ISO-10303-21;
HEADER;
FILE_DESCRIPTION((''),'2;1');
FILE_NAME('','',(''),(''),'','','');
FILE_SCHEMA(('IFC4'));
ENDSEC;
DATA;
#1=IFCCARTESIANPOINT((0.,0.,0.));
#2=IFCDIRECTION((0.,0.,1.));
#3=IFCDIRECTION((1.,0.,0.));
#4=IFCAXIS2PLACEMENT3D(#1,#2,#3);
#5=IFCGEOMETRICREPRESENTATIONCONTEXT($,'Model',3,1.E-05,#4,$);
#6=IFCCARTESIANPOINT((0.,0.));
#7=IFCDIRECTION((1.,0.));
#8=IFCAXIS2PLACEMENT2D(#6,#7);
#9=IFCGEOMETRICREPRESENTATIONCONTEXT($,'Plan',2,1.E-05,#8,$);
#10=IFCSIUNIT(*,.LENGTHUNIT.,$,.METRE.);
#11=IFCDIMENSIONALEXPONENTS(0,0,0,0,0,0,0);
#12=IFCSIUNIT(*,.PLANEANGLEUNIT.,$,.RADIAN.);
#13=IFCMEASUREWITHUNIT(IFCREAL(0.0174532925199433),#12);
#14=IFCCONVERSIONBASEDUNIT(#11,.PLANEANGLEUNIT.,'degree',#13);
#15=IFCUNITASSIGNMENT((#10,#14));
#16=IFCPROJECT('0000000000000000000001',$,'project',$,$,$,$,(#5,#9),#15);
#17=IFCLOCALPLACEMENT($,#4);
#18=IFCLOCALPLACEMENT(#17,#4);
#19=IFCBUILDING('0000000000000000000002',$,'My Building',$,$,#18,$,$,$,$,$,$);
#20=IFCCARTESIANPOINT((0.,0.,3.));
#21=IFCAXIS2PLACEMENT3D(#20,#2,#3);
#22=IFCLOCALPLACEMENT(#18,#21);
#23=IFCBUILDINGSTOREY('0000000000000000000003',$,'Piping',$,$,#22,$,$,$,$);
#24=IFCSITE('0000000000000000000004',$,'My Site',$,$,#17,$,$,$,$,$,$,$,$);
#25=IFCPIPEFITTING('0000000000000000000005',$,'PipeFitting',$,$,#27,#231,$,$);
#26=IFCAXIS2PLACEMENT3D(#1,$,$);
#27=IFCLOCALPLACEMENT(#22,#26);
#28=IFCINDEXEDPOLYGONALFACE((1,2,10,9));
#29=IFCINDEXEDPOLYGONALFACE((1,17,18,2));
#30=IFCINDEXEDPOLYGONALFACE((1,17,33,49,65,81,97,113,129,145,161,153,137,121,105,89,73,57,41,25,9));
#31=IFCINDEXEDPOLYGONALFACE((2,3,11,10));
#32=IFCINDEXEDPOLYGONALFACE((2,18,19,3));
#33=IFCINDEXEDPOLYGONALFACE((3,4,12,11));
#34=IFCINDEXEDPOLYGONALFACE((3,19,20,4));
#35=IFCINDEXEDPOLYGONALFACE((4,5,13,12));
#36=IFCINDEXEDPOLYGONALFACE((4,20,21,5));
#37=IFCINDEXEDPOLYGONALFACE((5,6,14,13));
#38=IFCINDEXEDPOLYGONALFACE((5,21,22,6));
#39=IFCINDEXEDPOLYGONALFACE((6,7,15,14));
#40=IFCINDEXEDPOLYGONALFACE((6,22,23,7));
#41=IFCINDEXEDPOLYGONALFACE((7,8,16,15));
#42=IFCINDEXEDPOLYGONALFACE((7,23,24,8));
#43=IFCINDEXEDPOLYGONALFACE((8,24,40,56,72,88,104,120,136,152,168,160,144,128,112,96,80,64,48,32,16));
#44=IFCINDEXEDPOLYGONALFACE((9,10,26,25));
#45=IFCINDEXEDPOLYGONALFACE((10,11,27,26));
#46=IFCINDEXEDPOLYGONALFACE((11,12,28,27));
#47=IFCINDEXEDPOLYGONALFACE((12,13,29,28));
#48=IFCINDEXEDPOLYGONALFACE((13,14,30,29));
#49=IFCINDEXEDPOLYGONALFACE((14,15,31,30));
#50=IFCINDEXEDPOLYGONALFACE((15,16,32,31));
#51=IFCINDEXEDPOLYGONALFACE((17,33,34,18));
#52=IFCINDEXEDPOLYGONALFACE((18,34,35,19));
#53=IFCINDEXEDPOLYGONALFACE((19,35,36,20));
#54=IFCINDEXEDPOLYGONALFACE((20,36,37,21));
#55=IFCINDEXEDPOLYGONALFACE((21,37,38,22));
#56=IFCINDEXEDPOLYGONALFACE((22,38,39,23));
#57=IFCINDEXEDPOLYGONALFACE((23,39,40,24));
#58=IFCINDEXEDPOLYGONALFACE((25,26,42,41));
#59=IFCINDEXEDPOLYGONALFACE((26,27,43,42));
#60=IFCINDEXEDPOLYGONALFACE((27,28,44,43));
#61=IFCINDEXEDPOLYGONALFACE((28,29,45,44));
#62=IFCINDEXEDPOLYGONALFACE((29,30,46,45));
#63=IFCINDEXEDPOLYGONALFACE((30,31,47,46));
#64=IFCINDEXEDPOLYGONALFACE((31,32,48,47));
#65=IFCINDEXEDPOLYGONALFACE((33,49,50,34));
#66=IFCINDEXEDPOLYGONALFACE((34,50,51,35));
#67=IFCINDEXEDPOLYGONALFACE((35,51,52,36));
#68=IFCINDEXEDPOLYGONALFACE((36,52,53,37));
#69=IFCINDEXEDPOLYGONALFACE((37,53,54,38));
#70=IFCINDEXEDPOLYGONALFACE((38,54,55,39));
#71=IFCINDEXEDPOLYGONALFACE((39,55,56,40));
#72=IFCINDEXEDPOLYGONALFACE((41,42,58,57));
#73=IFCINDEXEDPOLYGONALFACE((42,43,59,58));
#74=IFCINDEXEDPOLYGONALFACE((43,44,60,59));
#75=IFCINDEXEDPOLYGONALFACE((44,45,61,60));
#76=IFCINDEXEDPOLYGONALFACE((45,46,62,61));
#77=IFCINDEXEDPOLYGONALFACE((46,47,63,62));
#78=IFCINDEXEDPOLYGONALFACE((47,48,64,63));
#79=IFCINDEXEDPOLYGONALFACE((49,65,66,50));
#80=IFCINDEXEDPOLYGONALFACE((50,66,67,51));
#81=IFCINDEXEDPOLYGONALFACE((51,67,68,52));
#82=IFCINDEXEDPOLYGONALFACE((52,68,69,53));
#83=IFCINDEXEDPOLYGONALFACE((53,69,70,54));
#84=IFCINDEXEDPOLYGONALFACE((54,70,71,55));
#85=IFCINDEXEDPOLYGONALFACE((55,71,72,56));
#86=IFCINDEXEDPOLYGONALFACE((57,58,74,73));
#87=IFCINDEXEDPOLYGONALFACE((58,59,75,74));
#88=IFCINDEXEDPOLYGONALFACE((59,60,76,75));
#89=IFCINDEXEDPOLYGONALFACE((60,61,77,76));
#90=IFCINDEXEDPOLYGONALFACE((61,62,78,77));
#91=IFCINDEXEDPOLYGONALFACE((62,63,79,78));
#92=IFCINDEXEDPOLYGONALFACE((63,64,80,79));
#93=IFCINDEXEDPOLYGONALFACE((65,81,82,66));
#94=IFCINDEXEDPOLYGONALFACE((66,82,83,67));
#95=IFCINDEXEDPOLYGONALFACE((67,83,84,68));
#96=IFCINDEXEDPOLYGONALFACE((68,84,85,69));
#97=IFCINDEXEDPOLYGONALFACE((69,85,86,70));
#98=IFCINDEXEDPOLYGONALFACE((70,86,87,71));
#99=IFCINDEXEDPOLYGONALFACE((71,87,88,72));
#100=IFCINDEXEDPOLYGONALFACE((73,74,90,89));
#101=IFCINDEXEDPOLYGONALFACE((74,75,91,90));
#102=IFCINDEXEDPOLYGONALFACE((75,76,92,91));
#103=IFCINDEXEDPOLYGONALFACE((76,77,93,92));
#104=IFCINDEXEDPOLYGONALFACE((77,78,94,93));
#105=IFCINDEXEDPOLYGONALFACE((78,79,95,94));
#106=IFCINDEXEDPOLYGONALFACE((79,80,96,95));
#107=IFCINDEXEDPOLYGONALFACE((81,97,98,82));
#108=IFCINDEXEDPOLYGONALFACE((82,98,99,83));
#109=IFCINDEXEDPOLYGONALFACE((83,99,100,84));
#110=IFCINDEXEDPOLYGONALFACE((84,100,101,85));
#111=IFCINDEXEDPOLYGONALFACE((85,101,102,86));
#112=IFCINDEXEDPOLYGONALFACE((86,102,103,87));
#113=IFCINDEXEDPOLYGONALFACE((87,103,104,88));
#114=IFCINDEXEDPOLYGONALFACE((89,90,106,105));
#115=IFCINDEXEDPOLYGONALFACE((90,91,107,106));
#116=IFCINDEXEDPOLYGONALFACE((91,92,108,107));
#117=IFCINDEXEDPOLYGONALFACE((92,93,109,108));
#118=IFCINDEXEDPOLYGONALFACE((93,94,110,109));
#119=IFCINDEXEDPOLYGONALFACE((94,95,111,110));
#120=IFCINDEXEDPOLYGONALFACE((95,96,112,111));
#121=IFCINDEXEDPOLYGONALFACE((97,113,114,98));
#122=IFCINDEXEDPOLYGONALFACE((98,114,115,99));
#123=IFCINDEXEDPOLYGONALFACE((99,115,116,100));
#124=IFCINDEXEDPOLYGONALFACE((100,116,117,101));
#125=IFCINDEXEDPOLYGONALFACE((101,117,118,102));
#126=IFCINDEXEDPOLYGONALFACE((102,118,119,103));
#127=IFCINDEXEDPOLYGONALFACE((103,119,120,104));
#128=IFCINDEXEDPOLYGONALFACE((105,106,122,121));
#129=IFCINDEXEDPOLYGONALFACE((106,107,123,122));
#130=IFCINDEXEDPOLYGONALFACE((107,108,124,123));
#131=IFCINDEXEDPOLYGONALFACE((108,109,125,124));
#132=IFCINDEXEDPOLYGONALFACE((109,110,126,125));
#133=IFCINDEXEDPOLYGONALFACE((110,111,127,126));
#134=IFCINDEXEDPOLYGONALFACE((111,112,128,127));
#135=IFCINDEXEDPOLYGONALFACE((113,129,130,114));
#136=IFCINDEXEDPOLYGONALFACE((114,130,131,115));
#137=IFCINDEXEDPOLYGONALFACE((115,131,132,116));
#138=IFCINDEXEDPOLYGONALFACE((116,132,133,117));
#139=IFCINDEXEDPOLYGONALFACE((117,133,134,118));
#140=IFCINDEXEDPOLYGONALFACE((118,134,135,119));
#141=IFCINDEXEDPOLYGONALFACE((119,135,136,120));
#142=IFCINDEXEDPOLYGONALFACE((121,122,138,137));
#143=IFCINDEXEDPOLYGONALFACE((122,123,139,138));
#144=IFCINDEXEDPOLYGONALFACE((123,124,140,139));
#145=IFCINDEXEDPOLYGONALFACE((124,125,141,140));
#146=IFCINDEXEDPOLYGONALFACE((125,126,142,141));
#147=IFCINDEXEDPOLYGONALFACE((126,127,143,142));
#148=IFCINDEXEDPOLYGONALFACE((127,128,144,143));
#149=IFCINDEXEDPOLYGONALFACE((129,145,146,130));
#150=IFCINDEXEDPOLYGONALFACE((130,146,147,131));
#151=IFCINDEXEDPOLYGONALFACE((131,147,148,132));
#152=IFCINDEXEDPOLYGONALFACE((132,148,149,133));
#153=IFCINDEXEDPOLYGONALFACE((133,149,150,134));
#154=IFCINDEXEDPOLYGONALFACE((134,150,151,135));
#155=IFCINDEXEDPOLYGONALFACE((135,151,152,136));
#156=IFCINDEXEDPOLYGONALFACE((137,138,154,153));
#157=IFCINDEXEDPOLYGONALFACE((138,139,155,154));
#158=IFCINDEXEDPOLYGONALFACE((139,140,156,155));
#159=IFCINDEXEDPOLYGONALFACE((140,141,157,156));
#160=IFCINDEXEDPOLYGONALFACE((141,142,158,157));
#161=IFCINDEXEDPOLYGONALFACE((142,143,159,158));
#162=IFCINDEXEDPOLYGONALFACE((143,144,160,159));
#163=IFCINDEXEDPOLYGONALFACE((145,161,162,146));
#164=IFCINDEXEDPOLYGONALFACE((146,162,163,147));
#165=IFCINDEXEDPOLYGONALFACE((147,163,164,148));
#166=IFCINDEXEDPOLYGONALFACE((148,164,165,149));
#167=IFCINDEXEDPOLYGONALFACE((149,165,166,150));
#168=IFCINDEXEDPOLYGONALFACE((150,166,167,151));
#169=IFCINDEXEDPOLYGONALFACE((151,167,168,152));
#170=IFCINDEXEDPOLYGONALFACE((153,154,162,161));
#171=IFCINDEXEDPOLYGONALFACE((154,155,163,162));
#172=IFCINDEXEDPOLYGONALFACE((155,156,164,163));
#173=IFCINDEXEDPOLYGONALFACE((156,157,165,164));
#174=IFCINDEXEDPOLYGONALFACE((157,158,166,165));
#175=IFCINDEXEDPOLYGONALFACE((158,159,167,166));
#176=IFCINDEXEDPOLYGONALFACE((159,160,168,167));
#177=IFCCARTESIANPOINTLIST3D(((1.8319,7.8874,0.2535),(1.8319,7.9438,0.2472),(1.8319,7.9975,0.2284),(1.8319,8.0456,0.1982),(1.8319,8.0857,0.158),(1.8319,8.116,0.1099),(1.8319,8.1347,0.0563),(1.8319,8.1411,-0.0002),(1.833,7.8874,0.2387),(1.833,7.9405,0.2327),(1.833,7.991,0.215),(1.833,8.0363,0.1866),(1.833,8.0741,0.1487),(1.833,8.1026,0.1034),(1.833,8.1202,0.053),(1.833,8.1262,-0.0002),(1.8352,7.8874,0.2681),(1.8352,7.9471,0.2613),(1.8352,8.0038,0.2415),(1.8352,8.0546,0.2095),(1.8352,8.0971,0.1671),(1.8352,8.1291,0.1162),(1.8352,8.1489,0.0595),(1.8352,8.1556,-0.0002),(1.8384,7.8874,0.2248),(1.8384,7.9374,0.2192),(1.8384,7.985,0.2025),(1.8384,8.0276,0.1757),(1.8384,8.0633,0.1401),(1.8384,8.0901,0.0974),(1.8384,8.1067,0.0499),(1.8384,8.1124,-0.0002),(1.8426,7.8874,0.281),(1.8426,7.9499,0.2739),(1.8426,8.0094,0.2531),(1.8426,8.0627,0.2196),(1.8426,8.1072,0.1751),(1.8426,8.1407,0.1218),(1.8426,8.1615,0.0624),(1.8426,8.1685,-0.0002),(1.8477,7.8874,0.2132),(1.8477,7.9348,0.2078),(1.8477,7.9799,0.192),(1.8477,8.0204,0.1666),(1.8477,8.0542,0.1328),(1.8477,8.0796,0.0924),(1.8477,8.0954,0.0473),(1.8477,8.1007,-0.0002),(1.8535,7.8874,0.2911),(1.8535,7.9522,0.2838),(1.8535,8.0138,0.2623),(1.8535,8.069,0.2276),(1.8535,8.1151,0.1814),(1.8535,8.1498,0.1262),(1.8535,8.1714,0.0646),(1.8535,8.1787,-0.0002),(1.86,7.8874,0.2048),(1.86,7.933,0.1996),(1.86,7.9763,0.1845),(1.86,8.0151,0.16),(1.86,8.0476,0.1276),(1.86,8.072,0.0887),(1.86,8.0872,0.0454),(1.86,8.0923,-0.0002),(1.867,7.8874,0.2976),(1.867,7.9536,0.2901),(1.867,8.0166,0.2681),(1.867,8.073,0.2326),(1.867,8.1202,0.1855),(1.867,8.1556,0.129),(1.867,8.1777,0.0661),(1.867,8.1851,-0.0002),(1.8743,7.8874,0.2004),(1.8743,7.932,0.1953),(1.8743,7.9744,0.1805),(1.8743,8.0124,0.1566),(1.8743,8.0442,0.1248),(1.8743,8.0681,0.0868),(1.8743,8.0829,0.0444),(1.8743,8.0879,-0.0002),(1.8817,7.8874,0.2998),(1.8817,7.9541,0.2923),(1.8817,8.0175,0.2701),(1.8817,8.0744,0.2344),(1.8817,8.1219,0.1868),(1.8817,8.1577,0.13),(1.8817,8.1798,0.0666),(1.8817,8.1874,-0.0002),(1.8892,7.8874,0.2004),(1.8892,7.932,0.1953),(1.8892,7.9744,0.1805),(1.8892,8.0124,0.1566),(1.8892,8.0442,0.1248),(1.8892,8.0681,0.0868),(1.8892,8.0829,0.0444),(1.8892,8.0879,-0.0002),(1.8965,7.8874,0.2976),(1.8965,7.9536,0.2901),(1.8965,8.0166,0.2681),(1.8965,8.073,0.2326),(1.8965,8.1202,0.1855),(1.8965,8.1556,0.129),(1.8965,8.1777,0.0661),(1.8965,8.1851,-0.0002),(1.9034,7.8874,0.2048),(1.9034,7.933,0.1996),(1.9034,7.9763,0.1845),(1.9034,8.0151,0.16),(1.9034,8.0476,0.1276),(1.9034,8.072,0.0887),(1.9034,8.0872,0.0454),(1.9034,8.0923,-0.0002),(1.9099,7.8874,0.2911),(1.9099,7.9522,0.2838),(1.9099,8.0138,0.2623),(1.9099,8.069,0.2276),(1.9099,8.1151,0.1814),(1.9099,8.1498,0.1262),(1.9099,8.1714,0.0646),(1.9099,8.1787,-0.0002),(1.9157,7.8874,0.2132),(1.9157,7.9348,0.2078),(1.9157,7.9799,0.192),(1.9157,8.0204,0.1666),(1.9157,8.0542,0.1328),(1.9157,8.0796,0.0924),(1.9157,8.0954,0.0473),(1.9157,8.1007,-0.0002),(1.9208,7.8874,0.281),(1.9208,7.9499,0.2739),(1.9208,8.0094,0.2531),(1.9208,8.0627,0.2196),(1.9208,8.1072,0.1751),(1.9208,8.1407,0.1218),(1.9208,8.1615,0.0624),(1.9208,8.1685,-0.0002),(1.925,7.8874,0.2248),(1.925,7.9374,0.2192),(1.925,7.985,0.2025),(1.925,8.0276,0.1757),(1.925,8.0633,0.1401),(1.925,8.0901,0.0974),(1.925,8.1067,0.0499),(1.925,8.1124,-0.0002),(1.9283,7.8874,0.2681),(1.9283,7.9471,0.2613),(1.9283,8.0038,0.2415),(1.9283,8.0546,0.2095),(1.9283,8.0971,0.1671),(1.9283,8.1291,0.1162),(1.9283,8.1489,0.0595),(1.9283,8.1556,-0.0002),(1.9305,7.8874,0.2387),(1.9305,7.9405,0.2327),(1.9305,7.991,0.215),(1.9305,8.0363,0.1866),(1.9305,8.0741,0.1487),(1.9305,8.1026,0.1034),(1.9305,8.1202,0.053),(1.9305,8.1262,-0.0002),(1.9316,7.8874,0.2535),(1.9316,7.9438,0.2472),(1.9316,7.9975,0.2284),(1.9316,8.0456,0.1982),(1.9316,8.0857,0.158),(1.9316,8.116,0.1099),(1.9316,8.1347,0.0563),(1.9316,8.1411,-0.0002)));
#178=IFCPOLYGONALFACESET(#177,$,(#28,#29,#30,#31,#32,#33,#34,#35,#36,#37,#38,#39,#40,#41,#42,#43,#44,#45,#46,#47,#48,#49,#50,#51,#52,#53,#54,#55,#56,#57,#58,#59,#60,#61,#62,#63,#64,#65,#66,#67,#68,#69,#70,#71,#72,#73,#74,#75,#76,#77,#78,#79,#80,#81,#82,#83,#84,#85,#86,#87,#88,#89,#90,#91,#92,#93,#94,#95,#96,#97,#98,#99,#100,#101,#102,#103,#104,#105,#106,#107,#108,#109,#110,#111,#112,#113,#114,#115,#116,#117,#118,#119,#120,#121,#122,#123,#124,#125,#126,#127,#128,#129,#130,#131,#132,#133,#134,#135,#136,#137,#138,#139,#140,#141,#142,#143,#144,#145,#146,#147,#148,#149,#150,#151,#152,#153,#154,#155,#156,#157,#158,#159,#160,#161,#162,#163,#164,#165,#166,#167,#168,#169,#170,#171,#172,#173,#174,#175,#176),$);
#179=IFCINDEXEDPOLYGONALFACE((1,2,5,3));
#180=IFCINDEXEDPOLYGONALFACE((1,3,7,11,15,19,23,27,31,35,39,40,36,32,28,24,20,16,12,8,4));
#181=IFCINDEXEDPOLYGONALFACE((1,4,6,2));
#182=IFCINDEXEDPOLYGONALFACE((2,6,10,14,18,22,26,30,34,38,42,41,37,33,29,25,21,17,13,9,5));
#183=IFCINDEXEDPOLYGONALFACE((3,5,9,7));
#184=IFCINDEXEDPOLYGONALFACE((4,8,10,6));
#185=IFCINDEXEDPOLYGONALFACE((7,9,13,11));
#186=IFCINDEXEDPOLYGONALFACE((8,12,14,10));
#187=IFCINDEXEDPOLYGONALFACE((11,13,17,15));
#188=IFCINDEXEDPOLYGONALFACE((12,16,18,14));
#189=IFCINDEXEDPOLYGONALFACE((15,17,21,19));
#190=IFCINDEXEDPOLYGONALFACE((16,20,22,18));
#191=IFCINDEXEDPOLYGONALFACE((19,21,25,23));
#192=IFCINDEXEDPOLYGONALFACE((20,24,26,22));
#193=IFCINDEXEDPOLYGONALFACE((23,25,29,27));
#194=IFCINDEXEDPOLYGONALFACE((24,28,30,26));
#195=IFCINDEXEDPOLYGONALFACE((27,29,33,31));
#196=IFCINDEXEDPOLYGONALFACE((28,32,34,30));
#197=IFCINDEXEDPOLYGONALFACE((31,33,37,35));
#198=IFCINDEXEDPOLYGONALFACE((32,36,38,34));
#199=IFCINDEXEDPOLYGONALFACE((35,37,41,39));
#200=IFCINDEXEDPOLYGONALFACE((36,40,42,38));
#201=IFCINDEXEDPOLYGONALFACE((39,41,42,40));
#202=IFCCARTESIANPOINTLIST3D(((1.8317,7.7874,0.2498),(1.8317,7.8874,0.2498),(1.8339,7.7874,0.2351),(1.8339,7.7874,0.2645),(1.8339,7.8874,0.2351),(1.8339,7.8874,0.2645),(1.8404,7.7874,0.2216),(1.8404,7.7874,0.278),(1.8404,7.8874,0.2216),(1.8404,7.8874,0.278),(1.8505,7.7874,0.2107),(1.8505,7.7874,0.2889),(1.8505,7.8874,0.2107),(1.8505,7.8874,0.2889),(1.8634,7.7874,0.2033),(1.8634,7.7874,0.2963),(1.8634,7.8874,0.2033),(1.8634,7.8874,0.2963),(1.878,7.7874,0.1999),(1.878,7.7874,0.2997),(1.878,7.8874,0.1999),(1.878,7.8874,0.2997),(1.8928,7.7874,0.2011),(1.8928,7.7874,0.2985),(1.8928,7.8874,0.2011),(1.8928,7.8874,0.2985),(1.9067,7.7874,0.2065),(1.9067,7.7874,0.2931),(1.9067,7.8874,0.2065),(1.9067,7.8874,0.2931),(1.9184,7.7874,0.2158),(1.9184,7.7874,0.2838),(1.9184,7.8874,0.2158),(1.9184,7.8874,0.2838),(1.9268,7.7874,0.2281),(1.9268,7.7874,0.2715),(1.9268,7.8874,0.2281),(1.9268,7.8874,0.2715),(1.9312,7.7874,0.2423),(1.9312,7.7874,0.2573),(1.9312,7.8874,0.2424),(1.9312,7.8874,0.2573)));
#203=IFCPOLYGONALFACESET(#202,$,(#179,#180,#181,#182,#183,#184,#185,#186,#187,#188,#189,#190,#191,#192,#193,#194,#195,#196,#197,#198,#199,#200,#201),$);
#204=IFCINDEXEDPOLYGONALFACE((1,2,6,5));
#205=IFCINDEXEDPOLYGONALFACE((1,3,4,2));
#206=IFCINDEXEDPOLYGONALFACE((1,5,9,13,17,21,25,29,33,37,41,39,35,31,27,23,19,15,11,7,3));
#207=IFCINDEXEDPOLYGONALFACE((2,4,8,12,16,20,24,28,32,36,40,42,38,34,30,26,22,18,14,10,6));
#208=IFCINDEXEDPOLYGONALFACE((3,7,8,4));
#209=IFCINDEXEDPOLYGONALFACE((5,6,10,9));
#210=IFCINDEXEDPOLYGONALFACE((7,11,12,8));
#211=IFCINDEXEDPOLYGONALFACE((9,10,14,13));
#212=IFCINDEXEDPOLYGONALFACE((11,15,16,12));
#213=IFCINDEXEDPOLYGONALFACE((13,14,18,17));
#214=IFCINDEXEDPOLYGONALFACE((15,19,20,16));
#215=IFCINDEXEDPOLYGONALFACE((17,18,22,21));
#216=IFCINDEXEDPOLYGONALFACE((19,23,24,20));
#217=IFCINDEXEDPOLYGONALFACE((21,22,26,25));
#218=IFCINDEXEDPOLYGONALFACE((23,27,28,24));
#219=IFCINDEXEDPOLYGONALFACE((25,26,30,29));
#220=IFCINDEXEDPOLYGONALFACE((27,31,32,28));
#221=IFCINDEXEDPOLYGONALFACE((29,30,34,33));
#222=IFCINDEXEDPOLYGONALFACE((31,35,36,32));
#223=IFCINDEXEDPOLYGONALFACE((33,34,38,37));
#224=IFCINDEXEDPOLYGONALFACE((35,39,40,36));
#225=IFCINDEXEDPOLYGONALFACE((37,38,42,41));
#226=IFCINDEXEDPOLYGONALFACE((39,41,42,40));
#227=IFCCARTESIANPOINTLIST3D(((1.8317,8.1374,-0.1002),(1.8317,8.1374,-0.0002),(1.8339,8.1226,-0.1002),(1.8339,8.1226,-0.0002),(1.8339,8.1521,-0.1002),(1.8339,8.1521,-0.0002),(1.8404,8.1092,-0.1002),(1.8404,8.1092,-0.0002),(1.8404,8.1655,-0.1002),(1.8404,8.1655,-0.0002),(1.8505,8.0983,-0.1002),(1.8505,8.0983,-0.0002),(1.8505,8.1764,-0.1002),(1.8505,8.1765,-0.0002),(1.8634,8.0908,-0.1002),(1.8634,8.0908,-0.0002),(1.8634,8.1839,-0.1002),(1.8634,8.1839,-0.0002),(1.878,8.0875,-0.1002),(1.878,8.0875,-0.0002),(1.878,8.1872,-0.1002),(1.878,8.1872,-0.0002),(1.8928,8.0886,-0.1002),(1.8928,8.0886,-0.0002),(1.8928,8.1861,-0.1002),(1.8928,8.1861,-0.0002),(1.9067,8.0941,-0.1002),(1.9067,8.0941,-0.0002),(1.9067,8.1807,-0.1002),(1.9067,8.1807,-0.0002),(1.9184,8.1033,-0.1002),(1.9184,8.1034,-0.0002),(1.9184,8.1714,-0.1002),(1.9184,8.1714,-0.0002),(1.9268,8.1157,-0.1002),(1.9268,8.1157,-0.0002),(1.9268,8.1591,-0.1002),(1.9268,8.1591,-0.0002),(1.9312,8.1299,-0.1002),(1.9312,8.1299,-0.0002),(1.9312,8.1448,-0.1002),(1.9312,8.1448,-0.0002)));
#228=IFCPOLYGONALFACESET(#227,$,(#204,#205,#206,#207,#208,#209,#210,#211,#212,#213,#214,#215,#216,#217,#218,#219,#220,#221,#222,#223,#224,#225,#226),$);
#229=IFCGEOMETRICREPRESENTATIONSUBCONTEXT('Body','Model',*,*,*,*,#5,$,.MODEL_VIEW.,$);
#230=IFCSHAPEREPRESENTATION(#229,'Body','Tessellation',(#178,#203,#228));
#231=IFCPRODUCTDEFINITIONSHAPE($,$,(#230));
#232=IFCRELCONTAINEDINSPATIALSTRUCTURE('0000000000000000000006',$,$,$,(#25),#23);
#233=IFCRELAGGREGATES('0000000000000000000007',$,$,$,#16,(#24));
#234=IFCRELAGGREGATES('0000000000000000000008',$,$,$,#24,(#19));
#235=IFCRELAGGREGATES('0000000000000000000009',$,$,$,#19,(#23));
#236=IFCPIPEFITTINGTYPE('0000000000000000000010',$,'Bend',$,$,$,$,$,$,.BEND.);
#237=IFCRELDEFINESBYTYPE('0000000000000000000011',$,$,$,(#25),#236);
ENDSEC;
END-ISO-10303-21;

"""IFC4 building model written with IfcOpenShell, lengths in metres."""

from ifc_helpers import new_model, entity, si_unit, converted_unit, frame, origin_with_axes, origin_2d_with_axis, place, context, subcontext, project, spatial, circle, extrude, source, transform, mapped, type_object, type_shapes, element, save


model = new_model("IFC4")

# Units and contexts
model_context = context("Model", 3, precision=1e-05, world=origin_with_axes())
plan_context = context("Plan", 2, precision=1e-05, world=origin_2d_with_axis())
body_context = subcontext(model_context, "Body", "Model", "MODEL_VIEW")
ifc_project = project(units=[si_unit("LENGTHUNIT", "METRE"), converted_unit("PLANEANGLEUNIT", "degree", entity("IfcReal", 0.0174532925199433), si_unit("PLANEANGLEUNIT", "RADIAN"), dimensions=[0, 0, 0, 0, 0, 0, 0])], contexts=[model_context, plan_context])

# Site, building, storey
site_placement = place(None, origin_with_axes())
site = spatial("IfcSite", under=ifc_project, at=site_placement, Name="My Site")
building_placement = place(site_placement, origin_with_axes())
building = spatial("IfcBuilding", under=site, at=building_placement, Name="My Building")
storey_placement = place(building_placement, frame((0.0, 0.0, 3.0), z_axis=(0.0, 0.0, 1.0), x_axis=(1.0, 0.0, 0.0)))
storey = spatial("IfcBuildingStorey", under=building, at=storey_placement, Name="Piping")

# Pipe fitting
pipe_fitting_type_1 = type_object("IfcPipeFittingType", Name="Bend", PredefinedType="BEND")
shared_shape = source(origin_with_axes(), body_context, "Body", "SolidModel", [
    entity("IfcSweptDiskSolid", entity("IfcIndexedPolyCurve", entity("IfcCartesianPointList3D", [[0.0, 0.0, 0.1], [0.0, -0.0732, 0.2768], [0.0, -0.25, 0.35]]), [entity("IfcArcIndex", [1, 2, 3])]), 0.05),
    extrude(circle(Radius=0.05), origin_with_axes(), (0.0, 0.0, 1.0), 0.1),
    extrude(circle(Radius=0.05), frame((0.0, -0.25, 0.35), z_axis=(0.0, -1.0, -0.00003), x_axis=(1.0, 0.0, 0.0)), (0.0, 0.0, 1.0), 0.1),
])
type_shapes(pipe_fitting_type_1, [shared_shape])
for number, where, z_axis, x_axis, name in (
    (1, (1.8817, 7.7874, 0.2498), (0.0, 1.0, 0.000008), (-1.0, 0.0, 0.0), "PipeFitting"),
):
    element("IfcPipeFitting", number, at=place(storey_placement, frame(where, z_axis=z_axis, x_axis=x_axis)), inside=storey, type_object=pipe_fitting_type_1, Name=name, context=body_context, shape_type="MappedRepresentation", body=[
        mapped(shared_shape, transform((0.0, 0.0, 0.0), x_axis=(1.0, 0.0, 0.0), y_axis=(0.0, 1.0, 0.0), z_axis=(0.0, 0.0, 1.0), scale=1.0)),
    ])

save(model, "model.ifc")
